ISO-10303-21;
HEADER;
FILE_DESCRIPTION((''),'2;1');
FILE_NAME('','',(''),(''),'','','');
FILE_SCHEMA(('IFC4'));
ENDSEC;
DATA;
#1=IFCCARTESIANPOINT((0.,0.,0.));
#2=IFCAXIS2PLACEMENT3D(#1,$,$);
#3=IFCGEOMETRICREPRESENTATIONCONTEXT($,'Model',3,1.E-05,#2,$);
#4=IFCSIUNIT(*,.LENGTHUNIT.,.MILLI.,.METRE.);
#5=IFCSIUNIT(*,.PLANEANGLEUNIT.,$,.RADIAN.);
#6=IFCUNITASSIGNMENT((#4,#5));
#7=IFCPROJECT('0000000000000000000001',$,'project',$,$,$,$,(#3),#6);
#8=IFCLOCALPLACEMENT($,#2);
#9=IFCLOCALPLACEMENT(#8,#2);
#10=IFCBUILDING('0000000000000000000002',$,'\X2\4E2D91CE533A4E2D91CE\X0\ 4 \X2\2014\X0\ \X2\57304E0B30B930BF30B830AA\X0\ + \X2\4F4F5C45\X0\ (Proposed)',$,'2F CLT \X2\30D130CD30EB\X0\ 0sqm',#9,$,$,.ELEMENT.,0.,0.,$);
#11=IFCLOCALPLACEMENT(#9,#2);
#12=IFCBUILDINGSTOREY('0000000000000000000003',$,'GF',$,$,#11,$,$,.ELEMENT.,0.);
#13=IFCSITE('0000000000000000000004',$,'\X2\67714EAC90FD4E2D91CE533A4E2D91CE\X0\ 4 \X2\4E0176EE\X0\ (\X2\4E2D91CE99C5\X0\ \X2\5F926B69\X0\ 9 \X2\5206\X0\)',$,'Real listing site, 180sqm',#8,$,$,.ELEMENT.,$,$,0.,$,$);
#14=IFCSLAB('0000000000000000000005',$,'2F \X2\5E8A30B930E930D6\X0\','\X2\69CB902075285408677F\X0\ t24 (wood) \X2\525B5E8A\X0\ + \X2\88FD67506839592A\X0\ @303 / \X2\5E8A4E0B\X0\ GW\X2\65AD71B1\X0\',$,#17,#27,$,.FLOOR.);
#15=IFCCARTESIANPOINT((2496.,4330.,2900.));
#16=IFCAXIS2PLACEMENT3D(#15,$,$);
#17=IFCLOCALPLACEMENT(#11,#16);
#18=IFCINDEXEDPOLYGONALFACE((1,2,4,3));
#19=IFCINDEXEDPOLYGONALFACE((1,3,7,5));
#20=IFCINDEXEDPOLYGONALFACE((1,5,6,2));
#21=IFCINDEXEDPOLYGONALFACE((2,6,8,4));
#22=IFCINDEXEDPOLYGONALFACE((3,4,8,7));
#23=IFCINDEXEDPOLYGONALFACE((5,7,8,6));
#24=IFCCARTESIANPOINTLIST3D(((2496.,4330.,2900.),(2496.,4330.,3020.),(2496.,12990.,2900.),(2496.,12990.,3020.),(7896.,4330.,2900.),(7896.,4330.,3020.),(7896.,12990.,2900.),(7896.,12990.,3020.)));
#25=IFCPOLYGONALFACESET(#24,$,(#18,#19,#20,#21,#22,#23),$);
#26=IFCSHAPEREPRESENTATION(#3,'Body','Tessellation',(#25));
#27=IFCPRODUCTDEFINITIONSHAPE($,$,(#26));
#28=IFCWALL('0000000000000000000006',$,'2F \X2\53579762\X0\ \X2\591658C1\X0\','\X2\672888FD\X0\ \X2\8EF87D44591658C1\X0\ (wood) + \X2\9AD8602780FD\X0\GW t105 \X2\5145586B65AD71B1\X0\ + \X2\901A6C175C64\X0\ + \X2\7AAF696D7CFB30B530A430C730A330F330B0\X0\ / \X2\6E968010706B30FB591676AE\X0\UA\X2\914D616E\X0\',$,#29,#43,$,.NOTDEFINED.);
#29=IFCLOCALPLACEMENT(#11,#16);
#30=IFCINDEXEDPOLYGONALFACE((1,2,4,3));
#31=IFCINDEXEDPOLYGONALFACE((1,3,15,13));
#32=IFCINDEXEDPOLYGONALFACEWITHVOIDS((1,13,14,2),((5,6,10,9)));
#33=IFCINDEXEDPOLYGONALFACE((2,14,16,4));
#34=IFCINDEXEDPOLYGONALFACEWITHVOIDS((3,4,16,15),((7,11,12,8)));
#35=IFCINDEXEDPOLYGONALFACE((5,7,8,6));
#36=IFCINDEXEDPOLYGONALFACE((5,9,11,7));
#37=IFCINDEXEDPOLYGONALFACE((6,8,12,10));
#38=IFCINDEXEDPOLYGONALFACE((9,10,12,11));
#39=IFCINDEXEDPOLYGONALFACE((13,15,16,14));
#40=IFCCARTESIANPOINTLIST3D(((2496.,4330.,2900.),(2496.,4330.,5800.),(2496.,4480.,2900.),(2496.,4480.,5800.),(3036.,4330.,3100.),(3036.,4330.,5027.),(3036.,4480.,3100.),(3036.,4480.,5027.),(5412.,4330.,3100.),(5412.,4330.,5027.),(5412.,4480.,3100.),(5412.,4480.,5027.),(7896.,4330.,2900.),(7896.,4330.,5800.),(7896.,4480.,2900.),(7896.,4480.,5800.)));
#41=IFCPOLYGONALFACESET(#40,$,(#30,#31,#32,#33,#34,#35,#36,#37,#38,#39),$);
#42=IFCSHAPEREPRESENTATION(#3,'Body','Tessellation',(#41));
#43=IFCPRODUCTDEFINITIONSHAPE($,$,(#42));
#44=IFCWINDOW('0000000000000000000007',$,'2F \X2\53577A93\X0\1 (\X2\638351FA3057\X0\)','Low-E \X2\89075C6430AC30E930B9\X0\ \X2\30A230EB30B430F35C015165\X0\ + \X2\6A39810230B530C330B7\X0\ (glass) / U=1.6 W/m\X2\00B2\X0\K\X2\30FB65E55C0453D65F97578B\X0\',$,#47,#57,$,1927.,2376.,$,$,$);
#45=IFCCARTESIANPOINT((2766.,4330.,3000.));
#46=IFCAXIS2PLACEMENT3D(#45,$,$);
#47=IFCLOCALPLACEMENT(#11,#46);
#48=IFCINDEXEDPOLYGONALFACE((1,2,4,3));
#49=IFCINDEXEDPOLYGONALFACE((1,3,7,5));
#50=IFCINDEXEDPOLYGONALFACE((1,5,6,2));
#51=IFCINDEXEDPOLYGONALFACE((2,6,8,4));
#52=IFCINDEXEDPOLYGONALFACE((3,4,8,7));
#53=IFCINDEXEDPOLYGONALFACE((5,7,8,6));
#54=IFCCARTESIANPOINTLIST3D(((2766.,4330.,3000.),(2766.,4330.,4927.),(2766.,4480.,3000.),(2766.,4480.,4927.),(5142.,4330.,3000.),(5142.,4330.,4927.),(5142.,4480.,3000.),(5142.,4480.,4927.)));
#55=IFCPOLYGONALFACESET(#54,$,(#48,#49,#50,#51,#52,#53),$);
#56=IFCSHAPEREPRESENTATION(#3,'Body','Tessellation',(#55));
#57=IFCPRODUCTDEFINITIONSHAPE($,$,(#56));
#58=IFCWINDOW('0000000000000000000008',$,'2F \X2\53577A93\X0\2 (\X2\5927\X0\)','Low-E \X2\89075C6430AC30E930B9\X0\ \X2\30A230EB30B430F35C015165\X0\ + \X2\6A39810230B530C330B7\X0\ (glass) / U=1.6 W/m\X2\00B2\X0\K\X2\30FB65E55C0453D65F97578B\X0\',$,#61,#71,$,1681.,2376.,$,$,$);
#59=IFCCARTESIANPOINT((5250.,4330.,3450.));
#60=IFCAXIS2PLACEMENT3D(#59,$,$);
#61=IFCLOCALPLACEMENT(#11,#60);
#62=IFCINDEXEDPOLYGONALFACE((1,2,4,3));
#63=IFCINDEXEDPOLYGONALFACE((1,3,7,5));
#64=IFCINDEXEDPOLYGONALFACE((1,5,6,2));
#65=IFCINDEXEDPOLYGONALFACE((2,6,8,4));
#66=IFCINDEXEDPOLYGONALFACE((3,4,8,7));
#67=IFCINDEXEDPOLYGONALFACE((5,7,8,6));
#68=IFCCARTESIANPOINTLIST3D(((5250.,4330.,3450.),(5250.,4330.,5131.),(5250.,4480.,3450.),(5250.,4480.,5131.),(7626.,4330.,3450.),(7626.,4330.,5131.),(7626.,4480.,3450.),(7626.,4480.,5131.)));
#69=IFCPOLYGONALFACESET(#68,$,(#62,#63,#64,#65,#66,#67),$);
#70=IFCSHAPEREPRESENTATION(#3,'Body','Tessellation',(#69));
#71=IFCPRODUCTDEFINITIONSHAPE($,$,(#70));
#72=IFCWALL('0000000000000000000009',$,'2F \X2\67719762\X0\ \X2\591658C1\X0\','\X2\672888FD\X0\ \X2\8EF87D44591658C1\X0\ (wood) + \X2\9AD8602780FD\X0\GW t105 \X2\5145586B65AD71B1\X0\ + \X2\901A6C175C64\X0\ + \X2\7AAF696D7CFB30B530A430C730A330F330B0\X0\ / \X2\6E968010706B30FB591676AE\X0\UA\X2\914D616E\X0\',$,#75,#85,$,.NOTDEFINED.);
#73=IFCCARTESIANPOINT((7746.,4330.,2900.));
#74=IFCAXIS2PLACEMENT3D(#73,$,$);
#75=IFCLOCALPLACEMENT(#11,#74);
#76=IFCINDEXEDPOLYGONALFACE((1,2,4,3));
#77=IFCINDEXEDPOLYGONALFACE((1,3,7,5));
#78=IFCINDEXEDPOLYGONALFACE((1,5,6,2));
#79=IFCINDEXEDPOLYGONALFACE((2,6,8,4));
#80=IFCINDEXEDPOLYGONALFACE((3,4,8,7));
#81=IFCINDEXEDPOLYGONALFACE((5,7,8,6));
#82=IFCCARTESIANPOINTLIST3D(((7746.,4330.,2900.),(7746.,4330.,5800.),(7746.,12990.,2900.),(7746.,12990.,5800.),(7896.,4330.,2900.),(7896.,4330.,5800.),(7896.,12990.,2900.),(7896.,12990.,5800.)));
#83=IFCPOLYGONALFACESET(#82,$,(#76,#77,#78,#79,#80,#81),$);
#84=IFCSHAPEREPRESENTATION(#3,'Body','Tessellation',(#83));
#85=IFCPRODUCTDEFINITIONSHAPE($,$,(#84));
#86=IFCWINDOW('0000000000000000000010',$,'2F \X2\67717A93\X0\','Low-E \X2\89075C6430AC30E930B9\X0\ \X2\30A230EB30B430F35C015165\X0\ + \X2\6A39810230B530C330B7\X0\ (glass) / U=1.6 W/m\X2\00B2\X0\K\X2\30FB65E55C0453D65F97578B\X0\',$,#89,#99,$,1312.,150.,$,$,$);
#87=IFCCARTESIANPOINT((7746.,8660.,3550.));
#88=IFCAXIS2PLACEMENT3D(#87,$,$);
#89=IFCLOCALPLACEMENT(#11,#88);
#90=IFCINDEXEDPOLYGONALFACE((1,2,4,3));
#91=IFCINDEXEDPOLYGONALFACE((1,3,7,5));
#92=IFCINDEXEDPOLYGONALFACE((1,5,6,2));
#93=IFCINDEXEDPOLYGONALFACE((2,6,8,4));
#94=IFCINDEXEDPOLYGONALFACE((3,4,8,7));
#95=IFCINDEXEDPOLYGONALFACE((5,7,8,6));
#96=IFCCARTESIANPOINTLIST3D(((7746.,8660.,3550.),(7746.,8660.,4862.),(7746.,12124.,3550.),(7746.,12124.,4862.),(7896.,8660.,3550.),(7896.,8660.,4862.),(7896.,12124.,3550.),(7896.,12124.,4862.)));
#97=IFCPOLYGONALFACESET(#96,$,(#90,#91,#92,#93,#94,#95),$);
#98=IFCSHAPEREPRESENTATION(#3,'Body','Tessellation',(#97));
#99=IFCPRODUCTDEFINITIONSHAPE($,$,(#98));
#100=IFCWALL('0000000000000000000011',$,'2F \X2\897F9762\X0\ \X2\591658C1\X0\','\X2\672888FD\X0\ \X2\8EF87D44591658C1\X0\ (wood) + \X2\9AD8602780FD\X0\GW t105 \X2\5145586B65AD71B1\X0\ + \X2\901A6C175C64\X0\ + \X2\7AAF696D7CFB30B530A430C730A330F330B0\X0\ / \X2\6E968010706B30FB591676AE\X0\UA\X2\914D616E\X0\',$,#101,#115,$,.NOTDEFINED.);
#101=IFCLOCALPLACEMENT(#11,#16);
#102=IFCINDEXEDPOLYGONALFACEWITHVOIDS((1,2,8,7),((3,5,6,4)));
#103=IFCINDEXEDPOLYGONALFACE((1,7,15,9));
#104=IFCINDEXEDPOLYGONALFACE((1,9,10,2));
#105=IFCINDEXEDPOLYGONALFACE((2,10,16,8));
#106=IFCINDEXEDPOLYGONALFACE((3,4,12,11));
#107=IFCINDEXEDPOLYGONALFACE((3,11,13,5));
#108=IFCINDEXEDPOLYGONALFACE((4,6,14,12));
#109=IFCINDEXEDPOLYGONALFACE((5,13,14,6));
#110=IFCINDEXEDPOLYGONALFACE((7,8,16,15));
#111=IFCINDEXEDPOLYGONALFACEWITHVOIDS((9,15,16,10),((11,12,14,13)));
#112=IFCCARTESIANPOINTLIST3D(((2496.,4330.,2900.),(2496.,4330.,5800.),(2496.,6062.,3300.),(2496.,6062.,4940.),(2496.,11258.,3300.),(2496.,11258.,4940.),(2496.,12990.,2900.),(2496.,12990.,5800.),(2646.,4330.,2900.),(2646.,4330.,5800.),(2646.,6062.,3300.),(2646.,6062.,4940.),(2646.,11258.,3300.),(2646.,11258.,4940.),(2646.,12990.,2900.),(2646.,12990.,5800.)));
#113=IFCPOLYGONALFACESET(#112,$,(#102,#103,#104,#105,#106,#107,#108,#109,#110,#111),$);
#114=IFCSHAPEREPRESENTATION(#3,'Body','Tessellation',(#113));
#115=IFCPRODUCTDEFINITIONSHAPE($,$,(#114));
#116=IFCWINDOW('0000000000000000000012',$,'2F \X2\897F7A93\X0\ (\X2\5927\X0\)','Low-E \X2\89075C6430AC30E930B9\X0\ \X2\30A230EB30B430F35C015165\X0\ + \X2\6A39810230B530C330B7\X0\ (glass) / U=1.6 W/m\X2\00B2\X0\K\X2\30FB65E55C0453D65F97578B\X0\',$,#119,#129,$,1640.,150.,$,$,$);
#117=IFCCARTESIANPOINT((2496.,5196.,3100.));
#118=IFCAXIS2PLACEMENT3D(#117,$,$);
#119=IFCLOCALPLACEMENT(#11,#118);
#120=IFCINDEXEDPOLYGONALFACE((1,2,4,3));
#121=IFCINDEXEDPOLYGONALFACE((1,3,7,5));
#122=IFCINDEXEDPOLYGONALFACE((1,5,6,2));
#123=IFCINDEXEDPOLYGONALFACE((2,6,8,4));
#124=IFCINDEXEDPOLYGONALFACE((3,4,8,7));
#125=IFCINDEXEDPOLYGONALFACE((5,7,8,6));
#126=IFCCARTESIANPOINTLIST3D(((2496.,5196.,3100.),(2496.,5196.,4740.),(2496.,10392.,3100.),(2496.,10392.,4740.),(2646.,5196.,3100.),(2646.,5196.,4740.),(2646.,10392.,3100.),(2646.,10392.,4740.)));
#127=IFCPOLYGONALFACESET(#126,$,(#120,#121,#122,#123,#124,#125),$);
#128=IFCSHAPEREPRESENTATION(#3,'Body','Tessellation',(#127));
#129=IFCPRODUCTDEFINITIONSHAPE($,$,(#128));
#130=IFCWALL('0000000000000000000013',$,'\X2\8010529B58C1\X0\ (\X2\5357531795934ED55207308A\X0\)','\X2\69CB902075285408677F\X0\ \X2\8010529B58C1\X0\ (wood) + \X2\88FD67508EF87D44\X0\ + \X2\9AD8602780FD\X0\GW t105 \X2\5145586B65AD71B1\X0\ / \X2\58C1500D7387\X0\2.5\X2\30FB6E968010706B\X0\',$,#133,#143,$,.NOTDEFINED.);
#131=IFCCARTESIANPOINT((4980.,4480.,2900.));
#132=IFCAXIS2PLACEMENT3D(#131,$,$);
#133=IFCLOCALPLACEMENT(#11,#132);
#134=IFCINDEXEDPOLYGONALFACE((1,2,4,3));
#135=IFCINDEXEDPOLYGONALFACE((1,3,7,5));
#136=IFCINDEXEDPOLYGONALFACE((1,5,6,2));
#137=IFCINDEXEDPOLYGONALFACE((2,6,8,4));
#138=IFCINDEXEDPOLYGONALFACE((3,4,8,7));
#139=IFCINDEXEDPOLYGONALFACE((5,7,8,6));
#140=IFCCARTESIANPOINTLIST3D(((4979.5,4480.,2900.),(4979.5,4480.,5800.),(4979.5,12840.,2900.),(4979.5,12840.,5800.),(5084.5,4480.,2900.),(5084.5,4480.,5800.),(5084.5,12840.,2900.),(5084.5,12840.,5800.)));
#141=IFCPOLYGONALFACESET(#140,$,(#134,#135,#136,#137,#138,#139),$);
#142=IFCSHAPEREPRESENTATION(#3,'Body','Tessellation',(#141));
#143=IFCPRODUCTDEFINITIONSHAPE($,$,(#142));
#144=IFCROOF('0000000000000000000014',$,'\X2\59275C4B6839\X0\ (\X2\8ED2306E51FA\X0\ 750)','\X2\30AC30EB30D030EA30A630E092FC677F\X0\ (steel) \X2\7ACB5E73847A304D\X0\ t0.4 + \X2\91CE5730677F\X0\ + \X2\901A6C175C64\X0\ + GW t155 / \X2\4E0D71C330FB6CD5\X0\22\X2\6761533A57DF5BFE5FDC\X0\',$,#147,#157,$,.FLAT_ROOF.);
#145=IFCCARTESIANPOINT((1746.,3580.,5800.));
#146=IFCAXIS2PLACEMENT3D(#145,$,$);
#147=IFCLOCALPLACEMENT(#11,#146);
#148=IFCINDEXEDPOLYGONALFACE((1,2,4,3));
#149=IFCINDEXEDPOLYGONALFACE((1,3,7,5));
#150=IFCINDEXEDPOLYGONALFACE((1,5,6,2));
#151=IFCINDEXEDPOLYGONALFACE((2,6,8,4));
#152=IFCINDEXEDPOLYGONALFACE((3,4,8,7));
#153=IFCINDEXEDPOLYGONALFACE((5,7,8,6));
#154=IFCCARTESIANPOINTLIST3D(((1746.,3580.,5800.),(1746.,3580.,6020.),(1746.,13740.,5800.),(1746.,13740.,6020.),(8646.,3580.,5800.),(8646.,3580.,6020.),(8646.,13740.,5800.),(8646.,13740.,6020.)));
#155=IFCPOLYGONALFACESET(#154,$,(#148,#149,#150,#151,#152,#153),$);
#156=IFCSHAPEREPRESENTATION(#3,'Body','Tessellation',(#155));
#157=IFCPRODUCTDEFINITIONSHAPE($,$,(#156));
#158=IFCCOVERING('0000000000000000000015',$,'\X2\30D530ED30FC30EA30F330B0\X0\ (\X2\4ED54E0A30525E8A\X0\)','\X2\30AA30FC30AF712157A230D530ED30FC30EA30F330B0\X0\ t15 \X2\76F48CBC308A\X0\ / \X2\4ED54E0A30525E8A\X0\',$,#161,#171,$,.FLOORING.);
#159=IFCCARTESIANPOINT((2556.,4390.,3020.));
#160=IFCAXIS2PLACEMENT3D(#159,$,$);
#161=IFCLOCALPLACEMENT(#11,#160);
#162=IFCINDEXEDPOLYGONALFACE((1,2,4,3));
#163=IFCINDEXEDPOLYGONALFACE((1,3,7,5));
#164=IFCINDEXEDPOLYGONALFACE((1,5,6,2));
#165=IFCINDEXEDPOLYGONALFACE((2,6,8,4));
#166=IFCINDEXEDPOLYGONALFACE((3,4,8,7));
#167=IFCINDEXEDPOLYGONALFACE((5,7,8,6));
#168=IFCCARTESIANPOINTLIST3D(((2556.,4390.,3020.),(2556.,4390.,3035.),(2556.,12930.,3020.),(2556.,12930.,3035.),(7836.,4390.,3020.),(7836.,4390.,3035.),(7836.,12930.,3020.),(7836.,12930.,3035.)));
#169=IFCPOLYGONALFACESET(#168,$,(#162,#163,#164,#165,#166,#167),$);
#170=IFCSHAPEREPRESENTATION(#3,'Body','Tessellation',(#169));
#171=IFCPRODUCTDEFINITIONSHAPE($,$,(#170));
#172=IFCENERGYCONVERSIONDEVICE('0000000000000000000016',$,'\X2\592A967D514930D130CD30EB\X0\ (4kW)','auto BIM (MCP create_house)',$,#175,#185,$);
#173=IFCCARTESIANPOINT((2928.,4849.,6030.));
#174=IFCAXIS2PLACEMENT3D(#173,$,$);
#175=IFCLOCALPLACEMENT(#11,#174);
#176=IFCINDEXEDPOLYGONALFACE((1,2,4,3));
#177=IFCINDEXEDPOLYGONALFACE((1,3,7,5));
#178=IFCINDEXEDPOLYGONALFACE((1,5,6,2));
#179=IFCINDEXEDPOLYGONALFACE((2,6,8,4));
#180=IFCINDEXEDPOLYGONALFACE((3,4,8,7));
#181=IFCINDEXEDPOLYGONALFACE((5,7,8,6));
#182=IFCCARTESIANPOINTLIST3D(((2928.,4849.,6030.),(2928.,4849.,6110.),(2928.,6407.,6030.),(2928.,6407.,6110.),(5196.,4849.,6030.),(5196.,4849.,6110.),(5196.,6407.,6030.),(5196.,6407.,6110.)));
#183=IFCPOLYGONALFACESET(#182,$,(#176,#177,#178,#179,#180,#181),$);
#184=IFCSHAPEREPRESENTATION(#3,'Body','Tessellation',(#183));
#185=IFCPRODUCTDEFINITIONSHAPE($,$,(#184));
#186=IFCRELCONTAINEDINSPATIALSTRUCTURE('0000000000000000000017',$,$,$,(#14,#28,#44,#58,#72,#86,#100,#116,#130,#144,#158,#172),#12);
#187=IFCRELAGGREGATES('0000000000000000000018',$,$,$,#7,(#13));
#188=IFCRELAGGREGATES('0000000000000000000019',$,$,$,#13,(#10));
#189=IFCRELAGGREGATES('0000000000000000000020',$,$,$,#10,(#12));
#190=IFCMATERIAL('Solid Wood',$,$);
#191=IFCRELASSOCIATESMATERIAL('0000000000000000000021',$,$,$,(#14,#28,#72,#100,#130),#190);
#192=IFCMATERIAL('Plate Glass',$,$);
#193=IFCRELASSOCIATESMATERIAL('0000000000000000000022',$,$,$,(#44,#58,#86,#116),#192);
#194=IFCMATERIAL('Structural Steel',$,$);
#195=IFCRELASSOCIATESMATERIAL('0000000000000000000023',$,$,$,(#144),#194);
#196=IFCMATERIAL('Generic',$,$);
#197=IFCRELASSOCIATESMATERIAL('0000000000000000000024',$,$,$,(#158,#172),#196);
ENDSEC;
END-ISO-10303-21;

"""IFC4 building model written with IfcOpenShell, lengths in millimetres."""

from ifc_helpers import new_model, si_unit, frame, frame_2d, origin, place, context, project, spatial, rectangle, extrude, material, element, fill, save


model = new_model("IFC4")

# Units and contexts
model_context = context("Model", 3, precision=1e-05, world=origin())
ifc_project = project(units=[si_unit("LENGTHUNIT", "METRE", prefix="MILLI"), si_unit("PLANEANGLEUNIT", "RADIAN")], contexts=[model_context])

# Site, building, storey
site_placement = place(None, origin())
site = spatial("IfcSite", under=ifc_project, at=site_placement, Name="東京都中野区中野 4 丁目 (中野駅 徒歩 9 分)", ObjectType="Real listing site, 180sqm", CompositionType="ELEMENT", RefElevation=0.0)
building_placement = place(site_placement, origin())
building = spatial("IfcBuilding", under=site, at=building_placement, Name="中野区中野 4 — 地下スタジオ + 住居 (Proposed)", ObjectType="2F CLT パネル 0sqm", CompositionType="ELEMENT", ElevationOfRefHeight=0.0, ElevationOfTerrain=0.0)
storey_placement = place(building_placement, origin())
storey = spatial("IfcBuildingStorey", under=building, at=storey_placement, Name="GF", CompositionType="ELEMENT", Elevation=0.0)

# Slab
ifc_material_1 = material(Name="Solid Wood")
slab_placement = place(storey_placement, frame((2496.0, 4330.0, 2900.0)))
element("IfcSlab", 1, at=slab_placement, inside=storey, material=ifc_material_1, Name="2F 床スラブ", Description="構造用合板 t24 (wood) 剛床 + 製材根太 @303 / 床下 GW断熱", PredefinedType="FLOOR", context=model_context, shape_type="SweptSolid", body=[
    extrude(rectangle(XDim=5400.0, YDim=8660.0, at=frame_2d((2700.0, 4330.0))), frame((2496.0, 4330.0, 2900.0)), (0.0, 0.0, 1.0), 120.0),
])

# Wall, openings, windows
wall_1_placement = place(storey_placement, frame((2496.0, 4330.0, 2900.0)))
wall_1 = element("IfcWall", 2, at=wall_1_placement, inside=storey, material=ifc_material_1, Name="2F 南面 外壁", Description="木製 軸組外壁 (wood) + 高性能GW t105 充填断熱 + 通気層 + 窯業系サイディング / 準耐火・外皮UA配慮", PredefinedType="NOTDEFINED", context=model_context, shape_type="SweptSolid", body=[
    extrude(rectangle(XDim=5400.0, YDim=150.0, at=frame_2d((2700.0, 75.0))), frame((2496.0, 4330.0, 2900.0)), (0.0, 0.0, 1.0), 2900.0),
])
opening_1_placement = place(storey_placement, frame((2766.0, 4330.0, 3000.0)))
opening_1 = element("IfcOpeningElement", 3, at=opening_1_placement, cuts=wall_1, PredefinedType="NOTDEFINED", context=model_context, shape_type="SweptSolid", body=[
    extrude(rectangle(XDim=2376.0, YDim=150.0, at=frame_2d((1188.0, 75.0))), frame((2766.0, 4330.0, 3000.0)), (0.0, 0.0, 1.0), 1927.0),
])
opening_2_placement = place(storey_placement, frame((5250.0, 4330.0, 3450.0)))
opening_2 = element("IfcOpeningElement", 4, at=opening_2_placement, cuts=wall_1, PredefinedType="NOTDEFINED", context=model_context, shape_type="SweptSolid", body=[
    extrude(rectangle(XDim=2376.0, YDim=150.0, at=frame_2d((1188.0, 75.0))), frame((5250.0, 4330.0, 3450.0)), (0.0, 0.0, 1.0), 1681.0),
])
ifc_material_2 = material(Name="Plate Glass")
window_1_placement = place(storey_placement, frame((2766.0, 4330.0, 3000.0)))
window_1 = element("IfcWindow", 5, at=window_1_placement, inside=storey, material=ifc_material_2, Name="2F 南窓1 (掃出し)", Description="Low-E 複層ガラス アルゴン封入 + 樹脂サッシ (glass) / U=1.6 W/m²K・日射取得型", OverallHeight=1927.0, OverallWidth=2376.0, context=model_context, shape_type="SweptSolid", body=[
    extrude(rectangle(XDim=2376.0, YDim=150.0, at=frame_2d((1188.0, 75.0))), frame((2766.0, 4330.0, 3000.0)), (0.0, 0.0, 1.0), 1927.0),
])
fill(opening_1, window_1)
window_2_placement = place(storey_placement, frame((5250.0, 4330.0, 3450.0)))
window_2 = element("IfcWindow", 6, at=window_2_placement, inside=storey, material=ifc_material_2, Name="2F 南窓2 (大)", Description="Low-E 複層ガラス アルゴン封入 + 樹脂サッシ (glass) / U=1.6 W/m²K・日射取得型", OverallHeight=1681.0, OverallWidth=2376.0, context=model_context, shape_type="SweptSolid", body=[
    extrude(rectangle(XDim=2376.0, YDim=150.0, at=frame_2d((1188.0, 75.0))), frame((5250.0, 4330.0, 3450.0)), (0.0, 0.0, 1.0), 1681.0),
])
fill(opening_2, window_2)

# Walls, openings, windows
wall_2_placement = place(storey_placement, frame((7746.0, 4330.0, 2900.0)))
wall_2 = element("IfcWall", 7, at=wall_2_placement, inside=storey, material=ifc_material_1, Name="2F 東面 外壁", Description="木製 軸組外壁 (wood) + 高性能GW t105 充填断熱 + 通気層 + 窯業系サイディング / 準耐火・外皮UA配慮", PredefinedType="NOTDEFINED", context=model_context, shape_type="SweptSolid", body=[
    extrude(rectangle(XDim=150.0, YDim=8660.0, at=frame_2d((75.0, 4330.0))), frame((7746.0, 4330.0, 2900.0)), (0.0, 0.0, 1.0), 2900.0),
])
opening_3_placement = place(storey_placement, frame((7746.0, 8660.0, 3550.0)))
opening_3 = element("IfcOpeningElement", 8, at=opening_3_placement, cuts=wall_2, PredefinedType="NOTDEFINED", context=model_context, shape_type="SweptSolid", body=[
    extrude(rectangle(XDim=150.0, YDim=3464.0, at=frame_2d((75.0, 1732.0))), frame((7746.0, 8660.0, 3550.0)), (0.0, 0.0, 1.0), 1312.0),
])
window_3_placement = place(storey_placement, frame((7746.0, 8660.0, 3550.0)))
window_3 = element("IfcWindow", 9, at=window_3_placement, inside=storey, material=ifc_material_2, Name="2F 東窓", Description="Low-E 複層ガラス アルゴン封入 + 樹脂サッシ (glass) / U=1.6 W/m²K・日射取得型", OverallHeight=1312.0, OverallWidth=150.0, context=model_context, shape_type="SweptSolid", body=[
    extrude(rectangle(XDim=150.0, YDim=3464.0, at=frame_2d((75.0, 1732.0))), frame((7746.0, 8660.0, 3550.0)), (0.0, 0.0, 1.0), 1312.0),
])
fill(opening_3, window_3)
wall_3_placement = place(storey_placement, frame((2496.0, 4330.0, 2900.0)))
wall_3 = element("IfcWall", 10, at=wall_3_placement, inside=storey, material=ifc_material_1, Name="2F 西面 外壁", Description="木製 軸組外壁 (wood) + 高性能GW t105 充填断熱 + 通気層 + 窯業系サイディング / 準耐火・外皮UA配慮", PredefinedType="NOTDEFINED", context=model_context, shape_type="SweptSolid", body=[
    extrude(rectangle(XDim=150.0, YDim=8660.0, at=frame_2d((75.0, 4330.0))), frame((2496.0, 4330.0, 2900.0)), (0.0, 0.0, 1.0), 2900.0),
])
opening_4_placement = place(storey_placement, frame((2496.0, 5196.0, 3100.0)))
opening_4 = element("IfcOpeningElement", 11, at=opening_4_placement, cuts=wall_3, PredefinedType="NOTDEFINED", context=model_context, shape_type="SweptSolid", body=[
    extrude(rectangle(XDim=150.0, YDim=5196.0, at=frame_2d((75.0, 2598.0))), frame((2496.0, 5196.0, 3100.0)), (0.0, 0.0, 1.0), 1640.0),
])
window_4_placement = place(storey_placement, frame((2496.0, 5196.0, 3100.0)))
window_4 = element("IfcWindow", 12, at=window_4_placement, inside=storey, material=ifc_material_2, Name="2F 西窓 (大)", Description="Low-E 複層ガラス アルゴン封入 + 樹脂サッシ (glass) / U=1.6 W/m²K・日射取得型", OverallHeight=1640.0, OverallWidth=150.0, context=model_context, shape_type="SweptSolid", body=[
    extrude(rectangle(XDim=150.0, YDim=5196.0, at=frame_2d((75.0, 2598.0))), frame((2496.0, 5196.0, 3100.0)), (0.0, 0.0, 1.0), 1640.0),
])
fill(opening_4, window_4)

# Wall
wall_4_placement = place(storey_placement, frame((4980.0, 4480.0, 2900.0)))
element("IfcWall", 13, at=wall_4_placement, inside=storey, material=ifc_material_1, Name="耐力壁 (南北間仕切り)", Description="構造用合板 耐力壁 (wood) + 製材軸組 + 高性能GW t105 充填断熱 / 壁倍率2.5・準耐火", PredefinedType="NOTDEFINED", context=model_context, shape_type="SweptSolid", body=[
    extrude(rectangle(XDim=105.0, YDim=8360.0, at=frame_2d((52.0, 4180.0))), frame((4980.0, 4480.0, 2900.0)), (0.0, 0.0, 1.0), 2900.0),
])

# Roof
ifc_material_3 = material(Name="Structural Steel")
roof_placement = place(storey_placement, frame((1746.0, 3580.0, 5800.0)))
element("IfcRoof", 14, at=roof_placement, inside=storey, material=ifc_material_3, Name="大屋根 (軒の出 750)", Description="ガルバリウム鋼板 (steel) 立平葺き t0.4 + 野地板 + 通気層 + GW t155 / 不燃・法22条区域対応", PredefinedType="FLAT_ROOF", context=model_context, shape_type="SweptSolid", body=[
    extrude(rectangle(XDim=6900.0, YDim=10160.0, at=frame_2d((3450.0, 5080.0))), frame((1746.0, 3580.0, 5800.0)), (0.0, 0.0, 1.0), 220.0),
])

# Covering
ifc_material_4 = material(Name="Generic")
covering_placement = place(storey_placement, frame((2556.0, 4390.0, 3020.0)))
element("IfcCovering", 15, at=covering_placement, inside=storey, material=ifc_material_4, Name="フローリング (仕上げ床)", Description="オーク無垢フローリング t15 直貼り / 仕上げ床", PredefinedType="FLOORING", context=model_context, shape_type="SweptSolid", body=[
    extrude(rectangle(XDim=5280.0, YDim=8540.0, at=frame_2d((2640.0, 4270.0))), frame((2556.0, 4390.0, 3020.0)), (0.0, 0.0, 1.0), 15.0),
])

# Energy conversion device
energy_conversion_device_placement = place(storey_placement, frame((2928.0, 4849.0, 6030.0)))
element("IfcEnergyConversionDevice", 16, at=energy_conversion_device_placement, inside=storey, material=ifc_material_4, Name="太陽光パネル (4kW)", Description="auto BIM (MCP create_house)", context=model_context, shape_type="SweptSolid", body=[
    extrude(rectangle(XDim=2268.0, YDim=1558.0, at=frame_2d((1134.0, 779.0))), frame((2928.0, 4849.0, 6030.0)), (0.0, 0.0, 1.0), 80.0),
])

save(model, "model.ifc")
